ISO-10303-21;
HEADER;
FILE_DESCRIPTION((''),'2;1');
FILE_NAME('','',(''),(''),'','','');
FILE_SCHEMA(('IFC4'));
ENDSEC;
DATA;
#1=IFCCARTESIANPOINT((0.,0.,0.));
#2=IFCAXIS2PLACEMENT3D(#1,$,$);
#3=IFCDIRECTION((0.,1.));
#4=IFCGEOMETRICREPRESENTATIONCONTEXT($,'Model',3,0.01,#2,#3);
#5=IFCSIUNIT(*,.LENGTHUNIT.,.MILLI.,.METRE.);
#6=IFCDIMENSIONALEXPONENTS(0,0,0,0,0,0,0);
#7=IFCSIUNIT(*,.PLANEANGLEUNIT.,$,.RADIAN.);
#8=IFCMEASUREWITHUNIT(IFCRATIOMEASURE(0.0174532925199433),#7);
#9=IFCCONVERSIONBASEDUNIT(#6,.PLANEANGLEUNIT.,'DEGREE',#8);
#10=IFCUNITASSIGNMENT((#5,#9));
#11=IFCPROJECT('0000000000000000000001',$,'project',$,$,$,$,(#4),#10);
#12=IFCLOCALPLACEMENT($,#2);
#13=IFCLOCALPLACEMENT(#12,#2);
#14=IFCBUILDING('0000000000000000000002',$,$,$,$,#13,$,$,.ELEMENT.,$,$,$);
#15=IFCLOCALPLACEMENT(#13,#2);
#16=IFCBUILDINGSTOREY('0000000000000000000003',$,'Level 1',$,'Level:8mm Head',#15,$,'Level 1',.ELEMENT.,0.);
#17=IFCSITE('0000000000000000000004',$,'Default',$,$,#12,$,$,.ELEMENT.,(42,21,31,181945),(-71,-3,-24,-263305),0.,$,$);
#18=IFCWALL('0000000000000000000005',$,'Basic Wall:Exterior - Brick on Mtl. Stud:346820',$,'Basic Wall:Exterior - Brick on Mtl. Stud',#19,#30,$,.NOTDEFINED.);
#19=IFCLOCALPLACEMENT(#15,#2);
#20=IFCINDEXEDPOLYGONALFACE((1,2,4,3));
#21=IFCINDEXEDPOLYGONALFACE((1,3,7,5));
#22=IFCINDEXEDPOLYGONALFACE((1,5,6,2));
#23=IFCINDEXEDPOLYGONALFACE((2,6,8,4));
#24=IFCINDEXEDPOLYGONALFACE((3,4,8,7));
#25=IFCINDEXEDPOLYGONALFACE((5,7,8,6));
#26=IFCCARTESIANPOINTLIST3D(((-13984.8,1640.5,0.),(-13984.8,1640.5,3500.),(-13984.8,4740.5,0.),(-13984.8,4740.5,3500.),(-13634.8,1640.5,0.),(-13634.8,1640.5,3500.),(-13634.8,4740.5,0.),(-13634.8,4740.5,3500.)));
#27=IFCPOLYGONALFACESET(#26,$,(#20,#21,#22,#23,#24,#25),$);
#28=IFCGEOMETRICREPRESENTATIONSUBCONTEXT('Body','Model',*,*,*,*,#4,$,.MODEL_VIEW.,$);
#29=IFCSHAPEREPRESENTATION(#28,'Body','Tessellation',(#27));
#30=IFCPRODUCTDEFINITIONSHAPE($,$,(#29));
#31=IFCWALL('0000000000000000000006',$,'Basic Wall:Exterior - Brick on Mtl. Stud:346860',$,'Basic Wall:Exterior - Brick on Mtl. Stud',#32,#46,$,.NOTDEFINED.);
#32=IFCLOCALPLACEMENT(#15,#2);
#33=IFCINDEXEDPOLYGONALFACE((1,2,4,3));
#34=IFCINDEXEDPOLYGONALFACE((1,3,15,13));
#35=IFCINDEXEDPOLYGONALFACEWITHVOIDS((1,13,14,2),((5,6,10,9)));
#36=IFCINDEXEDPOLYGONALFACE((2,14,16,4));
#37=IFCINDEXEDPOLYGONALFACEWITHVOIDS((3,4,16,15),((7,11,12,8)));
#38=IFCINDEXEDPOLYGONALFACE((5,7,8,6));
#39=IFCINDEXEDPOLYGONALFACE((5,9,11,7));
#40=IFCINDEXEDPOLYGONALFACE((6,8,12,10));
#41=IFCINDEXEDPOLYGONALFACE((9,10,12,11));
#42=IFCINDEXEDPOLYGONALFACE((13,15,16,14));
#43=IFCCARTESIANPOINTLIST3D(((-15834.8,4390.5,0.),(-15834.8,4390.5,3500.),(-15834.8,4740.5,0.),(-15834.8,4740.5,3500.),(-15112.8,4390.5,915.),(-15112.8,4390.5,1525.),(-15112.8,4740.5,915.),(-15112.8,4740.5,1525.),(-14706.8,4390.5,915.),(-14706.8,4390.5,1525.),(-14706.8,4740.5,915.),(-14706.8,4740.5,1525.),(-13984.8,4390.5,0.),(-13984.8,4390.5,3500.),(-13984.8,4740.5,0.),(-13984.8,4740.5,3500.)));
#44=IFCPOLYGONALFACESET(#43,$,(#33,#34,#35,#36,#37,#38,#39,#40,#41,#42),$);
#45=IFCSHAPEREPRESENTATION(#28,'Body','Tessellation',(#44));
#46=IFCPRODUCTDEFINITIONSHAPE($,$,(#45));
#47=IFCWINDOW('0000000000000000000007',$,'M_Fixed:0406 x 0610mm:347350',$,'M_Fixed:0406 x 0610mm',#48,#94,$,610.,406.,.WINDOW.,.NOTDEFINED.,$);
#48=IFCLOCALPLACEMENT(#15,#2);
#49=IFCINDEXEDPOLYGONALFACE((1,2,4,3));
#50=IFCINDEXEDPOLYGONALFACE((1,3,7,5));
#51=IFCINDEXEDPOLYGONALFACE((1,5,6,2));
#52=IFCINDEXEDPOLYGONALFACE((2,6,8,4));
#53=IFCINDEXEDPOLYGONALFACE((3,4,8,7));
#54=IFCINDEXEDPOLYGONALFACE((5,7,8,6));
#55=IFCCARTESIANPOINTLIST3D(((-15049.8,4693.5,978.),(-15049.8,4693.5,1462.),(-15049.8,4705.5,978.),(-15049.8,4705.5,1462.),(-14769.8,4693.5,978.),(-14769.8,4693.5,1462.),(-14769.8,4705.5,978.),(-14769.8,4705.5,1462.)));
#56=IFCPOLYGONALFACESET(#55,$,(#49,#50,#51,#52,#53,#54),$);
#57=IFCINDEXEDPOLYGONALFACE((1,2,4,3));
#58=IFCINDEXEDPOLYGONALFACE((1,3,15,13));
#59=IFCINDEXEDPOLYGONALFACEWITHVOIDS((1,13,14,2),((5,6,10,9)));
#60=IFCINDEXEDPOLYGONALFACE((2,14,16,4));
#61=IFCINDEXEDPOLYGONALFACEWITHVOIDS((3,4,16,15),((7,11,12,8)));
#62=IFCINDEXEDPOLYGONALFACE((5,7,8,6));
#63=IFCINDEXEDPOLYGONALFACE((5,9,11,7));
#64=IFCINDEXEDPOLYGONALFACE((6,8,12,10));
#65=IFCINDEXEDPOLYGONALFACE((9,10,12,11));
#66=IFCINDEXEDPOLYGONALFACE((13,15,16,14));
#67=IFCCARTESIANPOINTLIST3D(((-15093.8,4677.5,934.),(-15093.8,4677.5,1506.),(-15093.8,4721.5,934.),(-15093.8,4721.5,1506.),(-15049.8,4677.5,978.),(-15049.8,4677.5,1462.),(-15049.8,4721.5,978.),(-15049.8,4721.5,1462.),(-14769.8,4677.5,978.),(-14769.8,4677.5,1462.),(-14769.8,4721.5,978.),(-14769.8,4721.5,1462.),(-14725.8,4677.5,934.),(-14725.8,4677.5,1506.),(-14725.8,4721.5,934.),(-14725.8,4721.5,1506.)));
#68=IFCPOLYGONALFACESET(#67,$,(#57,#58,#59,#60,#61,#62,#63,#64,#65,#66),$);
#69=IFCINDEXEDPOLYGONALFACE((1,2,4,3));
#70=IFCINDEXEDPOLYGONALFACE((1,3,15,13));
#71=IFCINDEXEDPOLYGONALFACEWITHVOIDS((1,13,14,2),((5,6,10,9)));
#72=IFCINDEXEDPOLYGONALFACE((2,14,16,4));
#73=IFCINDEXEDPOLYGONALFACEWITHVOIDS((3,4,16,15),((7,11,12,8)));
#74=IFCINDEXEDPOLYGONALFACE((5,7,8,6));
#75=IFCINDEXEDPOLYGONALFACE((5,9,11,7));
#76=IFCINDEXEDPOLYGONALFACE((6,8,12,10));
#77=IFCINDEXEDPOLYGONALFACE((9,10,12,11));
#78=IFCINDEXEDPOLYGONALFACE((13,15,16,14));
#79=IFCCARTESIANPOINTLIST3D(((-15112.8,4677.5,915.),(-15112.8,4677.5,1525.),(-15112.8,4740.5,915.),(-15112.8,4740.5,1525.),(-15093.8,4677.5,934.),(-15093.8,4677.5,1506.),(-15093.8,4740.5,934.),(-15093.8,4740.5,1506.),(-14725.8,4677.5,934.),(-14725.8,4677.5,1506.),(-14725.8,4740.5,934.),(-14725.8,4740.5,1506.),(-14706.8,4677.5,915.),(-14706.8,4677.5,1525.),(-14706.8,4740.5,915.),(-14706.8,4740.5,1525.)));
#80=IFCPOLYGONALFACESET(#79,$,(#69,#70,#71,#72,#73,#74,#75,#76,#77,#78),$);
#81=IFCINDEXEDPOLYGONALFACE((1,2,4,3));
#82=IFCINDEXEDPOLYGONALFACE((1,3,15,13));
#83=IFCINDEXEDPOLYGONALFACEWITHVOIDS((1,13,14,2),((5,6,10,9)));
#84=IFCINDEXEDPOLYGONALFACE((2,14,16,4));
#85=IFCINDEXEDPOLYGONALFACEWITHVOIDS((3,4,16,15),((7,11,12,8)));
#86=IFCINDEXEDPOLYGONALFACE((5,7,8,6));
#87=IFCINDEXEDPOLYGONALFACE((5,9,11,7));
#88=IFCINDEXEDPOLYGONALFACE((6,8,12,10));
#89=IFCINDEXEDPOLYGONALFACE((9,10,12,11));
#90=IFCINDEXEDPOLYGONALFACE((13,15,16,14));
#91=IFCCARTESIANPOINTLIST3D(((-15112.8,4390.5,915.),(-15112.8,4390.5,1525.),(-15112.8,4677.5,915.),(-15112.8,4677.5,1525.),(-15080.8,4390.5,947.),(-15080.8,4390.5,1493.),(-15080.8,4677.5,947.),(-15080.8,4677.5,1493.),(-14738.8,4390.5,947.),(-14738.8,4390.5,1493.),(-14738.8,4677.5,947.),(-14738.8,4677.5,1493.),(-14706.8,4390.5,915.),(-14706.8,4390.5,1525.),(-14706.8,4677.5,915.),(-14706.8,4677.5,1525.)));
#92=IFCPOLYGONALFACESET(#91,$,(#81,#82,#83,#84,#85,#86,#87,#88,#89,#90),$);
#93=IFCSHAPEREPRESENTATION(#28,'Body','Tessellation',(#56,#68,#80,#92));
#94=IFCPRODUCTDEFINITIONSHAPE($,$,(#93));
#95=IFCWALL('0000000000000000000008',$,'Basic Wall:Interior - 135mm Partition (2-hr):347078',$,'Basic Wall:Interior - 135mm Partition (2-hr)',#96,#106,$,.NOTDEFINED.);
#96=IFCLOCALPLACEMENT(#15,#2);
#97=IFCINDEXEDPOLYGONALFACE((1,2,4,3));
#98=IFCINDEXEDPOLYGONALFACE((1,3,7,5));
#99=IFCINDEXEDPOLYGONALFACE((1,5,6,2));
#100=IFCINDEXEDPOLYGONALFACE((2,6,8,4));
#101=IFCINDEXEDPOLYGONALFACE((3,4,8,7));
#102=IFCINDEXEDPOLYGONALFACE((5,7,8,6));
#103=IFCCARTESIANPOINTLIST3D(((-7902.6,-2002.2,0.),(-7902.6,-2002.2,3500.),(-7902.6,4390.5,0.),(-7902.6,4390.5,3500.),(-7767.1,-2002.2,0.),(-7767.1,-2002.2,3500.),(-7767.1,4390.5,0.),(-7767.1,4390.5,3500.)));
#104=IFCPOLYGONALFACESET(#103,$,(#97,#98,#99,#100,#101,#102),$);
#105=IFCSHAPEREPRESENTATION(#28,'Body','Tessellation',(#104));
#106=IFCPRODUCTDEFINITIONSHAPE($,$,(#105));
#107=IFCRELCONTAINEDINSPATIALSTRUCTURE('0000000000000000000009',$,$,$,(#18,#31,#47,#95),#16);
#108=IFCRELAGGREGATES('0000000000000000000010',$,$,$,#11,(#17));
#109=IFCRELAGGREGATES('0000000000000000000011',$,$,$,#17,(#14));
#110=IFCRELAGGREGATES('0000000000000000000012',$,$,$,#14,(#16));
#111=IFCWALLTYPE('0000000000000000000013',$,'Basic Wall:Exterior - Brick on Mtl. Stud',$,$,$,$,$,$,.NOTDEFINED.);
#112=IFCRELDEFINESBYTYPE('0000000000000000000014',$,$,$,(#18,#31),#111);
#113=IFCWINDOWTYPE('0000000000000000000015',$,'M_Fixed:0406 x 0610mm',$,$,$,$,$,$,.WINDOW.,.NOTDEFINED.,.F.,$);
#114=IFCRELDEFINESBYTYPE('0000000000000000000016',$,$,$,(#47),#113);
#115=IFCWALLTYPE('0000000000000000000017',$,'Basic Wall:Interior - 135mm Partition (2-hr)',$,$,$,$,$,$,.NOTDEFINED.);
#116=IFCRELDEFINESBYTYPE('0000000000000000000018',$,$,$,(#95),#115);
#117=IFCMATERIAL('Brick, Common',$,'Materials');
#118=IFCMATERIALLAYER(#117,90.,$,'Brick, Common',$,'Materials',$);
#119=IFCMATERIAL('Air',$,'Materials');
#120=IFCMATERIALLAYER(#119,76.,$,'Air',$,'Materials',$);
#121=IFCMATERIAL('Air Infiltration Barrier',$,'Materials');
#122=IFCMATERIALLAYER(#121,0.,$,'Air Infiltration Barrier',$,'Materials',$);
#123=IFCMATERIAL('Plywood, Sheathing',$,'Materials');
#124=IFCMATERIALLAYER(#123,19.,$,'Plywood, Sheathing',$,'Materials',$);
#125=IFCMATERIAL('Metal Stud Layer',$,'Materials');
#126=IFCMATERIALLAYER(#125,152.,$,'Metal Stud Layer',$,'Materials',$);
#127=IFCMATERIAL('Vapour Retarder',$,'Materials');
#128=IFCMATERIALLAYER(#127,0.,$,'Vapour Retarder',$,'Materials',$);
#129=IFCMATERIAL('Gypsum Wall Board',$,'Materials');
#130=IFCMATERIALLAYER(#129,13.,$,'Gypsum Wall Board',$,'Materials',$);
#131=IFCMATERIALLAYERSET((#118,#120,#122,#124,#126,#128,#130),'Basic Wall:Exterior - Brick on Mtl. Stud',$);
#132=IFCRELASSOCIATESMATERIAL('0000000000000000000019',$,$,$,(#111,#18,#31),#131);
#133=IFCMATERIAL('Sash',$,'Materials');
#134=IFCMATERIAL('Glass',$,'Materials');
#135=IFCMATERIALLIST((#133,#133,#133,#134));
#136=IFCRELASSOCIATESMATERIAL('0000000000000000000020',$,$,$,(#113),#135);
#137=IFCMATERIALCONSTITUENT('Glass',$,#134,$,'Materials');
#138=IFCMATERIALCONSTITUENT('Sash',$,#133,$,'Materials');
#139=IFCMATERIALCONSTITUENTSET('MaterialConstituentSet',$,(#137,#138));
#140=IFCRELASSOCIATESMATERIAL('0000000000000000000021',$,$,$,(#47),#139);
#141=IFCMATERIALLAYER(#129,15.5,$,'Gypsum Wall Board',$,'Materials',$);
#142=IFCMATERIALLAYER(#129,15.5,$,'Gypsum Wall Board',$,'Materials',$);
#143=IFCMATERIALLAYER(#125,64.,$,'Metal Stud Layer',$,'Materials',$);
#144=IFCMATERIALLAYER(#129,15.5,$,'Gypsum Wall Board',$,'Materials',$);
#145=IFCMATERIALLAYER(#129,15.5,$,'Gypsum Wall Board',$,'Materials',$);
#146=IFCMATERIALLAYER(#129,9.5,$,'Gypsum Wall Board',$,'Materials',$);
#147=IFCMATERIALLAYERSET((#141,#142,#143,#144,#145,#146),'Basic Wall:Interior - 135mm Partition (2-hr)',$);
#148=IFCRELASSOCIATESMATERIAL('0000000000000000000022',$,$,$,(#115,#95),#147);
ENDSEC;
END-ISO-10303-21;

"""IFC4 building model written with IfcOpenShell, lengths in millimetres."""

from ifc_helpers import new_model, entity, si_unit, converted_unit, direction, frame, frame_2d, origin, place, context, subcontext, project, spatial, polyline, rectangle, outline, extrude, source, transform, mapped, material, material_list, layer, layer_set, layer_usage, constituent, constituent_set, type_object, type_shapes, element, fill, save


model = new_model("IFC4")

# Units and contexts
model_context = context("Model", 3, precision=0.01, world=origin(), true_north=direction((0.0, 1.0)))
body_context = subcontext(model_context, "Body", "Model", "MODEL_VIEW")
ifc_project = project(units=[si_unit("LENGTHUNIT", "METRE", prefix="MILLI"), converted_unit("PLANEANGLEUNIT", "DEGREE", entity("IfcRatioMeasure", 0.0174532925199433), si_unit("PLANEANGLEUNIT", "RADIAN"), dimensions=[0, 0, 0, 0, 0, 0, 0])], contexts=[model_context])

# Site, building, storey
site_placement = place(None, origin())
site = spatial("IfcSite", under=ifc_project, at=site_placement, Name="Default", CompositionType="ELEMENT", RefLatitude=(42, 21, 31, 181945), RefLongitude=(-71, -3, -24, -263305), RefElevation=0.0)
building_placement = place(site_placement, origin())
building = spatial("IfcBuilding", under=site, at=building_placement, CompositionType="ELEMENT")
storey_placement = place(building_placement, origin())
storey = spatial("IfcBuildingStorey", under=building, at=storey_placement, Name="Level 1", ObjectType="Level:8mm Head", LongName="Level 1", CompositionType="ELEMENT", Elevation=0.0)

# Shared definitions
ifc_material_1 = material(Name="Brick, Common", Category="Materials")
ifc_layer_1 = layer(ifc_material_1, 90.0, Name="Brick, Common", Category="Materials")
ifc_material_2 = material(Name="Air", Category="Materials")
ifc_layer_2 = layer(ifc_material_2, 76.0, Name="Air", Category="Materials")
ifc_material_3 = material(Name="Air Infiltration Barrier", Category="Materials")
ifc_layer_3 = layer(ifc_material_3, 0.0, Name="Air Infiltration Barrier", Category="Materials")
ifc_material_4 = material(Name="Plywood, Sheathing", Category="Materials")
ifc_layer_4 = layer(ifc_material_4, 19.0, Name="Plywood, Sheathing", Category="Materials")
ifc_material_5 = material(Name="Metal Stud Layer", Category="Materials")
ifc_layer_5 = layer(ifc_material_5, 152.0, Name="Metal Stud Layer", Category="Materials")
ifc_material_6 = material(Name="Vapour Retarder", Category="Materials")
ifc_layer_6 = layer(ifc_material_6, 0.0, Name="Vapour Retarder", Category="Materials")
ifc_material_7 = material(Name="Gypsum Wall Board", Category="Materials")
ifc_layer_7 = layer(ifc_material_7, 13.0, Name="Gypsum Wall Board", Category="Materials")
ifc_layer_set_1 = layer_set([ifc_layer_1, ifc_layer_2, ifc_layer_3, ifc_layer_4, ifc_layer_5, ifc_layer_6, ifc_layer_7], Name="Basic Wall:Exterior - Brick on Mtl. Stud")
wall_type_1 = type_object("IfcWallType", Name="Basic Wall:Exterior - Brick on Mtl. Stud", PredefinedType="NOTDEFINED", material=ifc_layer_set_1)
ifc_material_8 = material(Name="Glass", Category="Materials")
ifc_material_9 = material(Name="Sash", Category="Materials")
ifc_material_list_1 = material_list([ifc_material_9, ifc_material_9, ifc_material_9, ifc_material_8])
window_type_1 = type_object("IfcWindowType", Name="M_Fixed:0406 x 0610mm", ParameterTakesPrecedence=False, PartitioningType="NOTDEFINED", PredefinedType="WINDOW", material=ifc_material_list_1)
shared_shape_1 = source(origin(), body_context, "Body", "SweptSolid", [
    extrude(rectangle(XDim=12.0, YDim=280.0, at=frame_2d((0.0, 0.0), x_axis=(1.0, 0.0))), frame((203.0, 309.0, 63.0), z_axis=(0.0, 0.0, 1.0), x_axis=(0.0, -1.0, 0.0)), (0.0, 0.0, 1.0), 484.0),
    extrude(outline(polyline([(-184.0, -286.0), (184.0, -286.0), (184.0, 286.0), (-184.0, 286.0), (-184.0, -286.0)]), holes=[polyline([(-140.0, -242.0), (-140.0, 242.0), (140.0, 242.0), (140.0, -242.0), (-140.0, -242.0)])]), frame((203.0, 287.0, 305.0), z_axis=(0.0, 1.0, 0.0), x_axis=(1.0, 0.0, 0.0)), (0.0, 0.0, 1.0), 44.0),
    extrude(outline(polyline([(-203.0, -305.0), (203.0, -305.0), (203.0, 305.0), (-203.0, 305.0), (-203.0, -305.0)]), holes=[polyline([(-184.0, -286.0), (-184.0, 286.0), (184.0, 286.0), (184.0, -286.0), (-184.0, -286.0)])]), frame((203.0, 287.0, 305.0), z_axis=(0.0, 1.0, 0.0), x_axis=(1.0, 0.0, 0.0)), (0.0, 0.0, 1.0), 63.0),
    extrude(outline(polyline([(-203.0, -305.0), (203.0, -305.0), (203.0, 305.0), (-203.0, 305.0), (-203.0, -305.0)]), holes=[polyline([(-171.0, -273.0), (-171.0, 273.0), (171.0, 273.0), (171.0, -273.0), (-171.0, -273.0)])]), frame((203.0, 0.0, 305.0), z_axis=(0.0, 1.0, 0.0), x_axis=(1.0, 0.0, 0.0)), (0.0, 0.0, 1.0), 287.0),
])
type_shapes(window_type_1, [shared_shape_1])

# Wall
ifc_layer_usage_1 = layer_usage(ifc_layer_set_1, "AXIS2", "NEGATIVE", 175.0)
wall_1_placement = place(storey_placement, frame((-13809.8, 1640.5, 0.0), z_axis=(0.0, 0.0, 1.0), x_axis=(0.0, 1.0, 0.0)))
element("IfcWall", 1, at=wall_1_placement, inside=storey, type_object=wall_type_1, material=ifc_layer_usage_1, Name="Basic Wall:Exterior - Brick on Mtl. Stud:346820", ObjectType="Basic Wall:Exterior - Brick on Mtl. Stud", PredefinedType="NOTDEFINED", context=body_context, shape_type="SweptSolid", body=[
    extrude(rectangle(XDim=3100.0, YDim=350.0, at=frame_2d((1550.0, 0.0), x_axis=(-1.0, 0.0))), origin(), (0.0, 0.0, 1.0), 3500.0),
])

# Wall, opening, window
ifc_layer_usage_2 = layer_usage(ifc_layer_set_1, "AXIS2", "NEGATIVE", 175.0)
wall_2_placement = place(storey_placement, frame((-13984.8, 4565.5, 0.0), z_axis=(0.0, 0.0, 1.0), x_axis=(-1.0, 0.0, 0.0)))
wall_2 = element("IfcWall", 2, at=wall_2_placement, inside=storey, type_object=wall_type_1, material=ifc_layer_usage_2, Name="Basic Wall:Exterior - Brick on Mtl. Stud:346860", ObjectType="Basic Wall:Exterior - Brick on Mtl. Stud", PredefinedType="NOTDEFINED", context=body_context, shape_type="SweptSolid", body=[
    extrude(rectangle(XDim=1850.0, YDim=350.0, at=frame_2d((925.0, 0.0), x_axis=(-1.0, 0.0))), origin(), (0.0, 0.0, 1.0), 3500.0),
])
opening_1_placement = place(wall_2_placement, frame((1128.0, 175.0, 915.0)))
opening_1 = element("IfcOpeningElement", 3, at=opening_1_placement, cuts=wall_2, ObjectType="Opening", PredefinedType="OPENING", context=body_context, shape_type="SweptSolid", body=[
    extrude(rectangle(XDim=610.0, YDim=406.0, at=frame_2d((305.0, 203.0), x_axis=(1.0, 0.0))), frame((0.0, 0.0, 0.0), z_axis=(0.0, -1.0, 0.0), x_axis=(0.0, 0.0, 1.0)), (0.0, 0.0, 1.0), 350.0),
])
ifc_constituent_1 = constituent(ifc_material_8, Name="Glass", Category="Materials")
ifc_constituent_2 = constituent(ifc_material_9, Name="Sash", Category="Materials")
ifc_constituent_set_1 = constituent_set(constituents=[ifc_constituent_1, ifc_constituent_2], Name="MaterialConstituentSet")
window_1_placement = place(opening_1_placement, frame((0.0, 0.0, 0.0), z_axis=(0.0, 0.0, 1.0), x_axis=(-1.0, 0.0, 0.0)))
window_1 = element("IfcWindow", 4, at=window_1_placement, inside=storey, type_object=window_type_1, material=ifc_constituent_set_1, Name="M_Fixed:0406 x 0610mm:347350", ObjectType="M_Fixed:0406 x 0610mm", OverallHeight=610.0, OverallWidth=406.0, PartitioningType="NOTDEFINED", PredefinedType="WINDOW", context=body_context, shape_type="MappedRepresentation", body=[
    mapped(shared_shape_1, transform((0.0, 0.0, 0.0), scale=1.0)),
])
fill(opening_1, window_1)

# Wall
ifc_layer_8 = layer(ifc_material_7, 15.5, Name="Gypsum Wall Board", Category="Materials")
ifc_layer_9 = layer(ifc_material_7, 15.5, Name="Gypsum Wall Board", Category="Materials")
ifc_layer_10 = layer(ifc_material_5, 64.0, Name="Metal Stud Layer", Category="Materials")
ifc_layer_11 = layer(ifc_material_7, 15.5, Name="Gypsum Wall Board", Category="Materials")
ifc_layer_12 = layer(ifc_material_7, 15.5, Name="Gypsum Wall Board", Category="Materials")
ifc_layer_13 = layer(ifc_material_7, 9.5, Name="Gypsum Wall Board", Category="Materials")
ifc_layer_set_2 = layer_set([ifc_layer_8, ifc_layer_9, ifc_layer_10, ifc_layer_11, ifc_layer_12, ifc_layer_13], Name="Basic Wall:Interior - 135mm Partition (2-hr)")
ifc_layer_usage_3 = layer_usage(ifc_layer_set_2, "AXIS2", "NEGATIVE", 67.8)
wall_type_2 = type_object("IfcWallType", Name="Basic Wall:Interior - 135mm Partition (2-hr)", PredefinedType="NOTDEFINED", material=ifc_layer_set_2)
wall_3_placement = place(storey_placement, frame((-7834.8, 4390.5, 0.0), z_axis=(0.0, 0.0, 1.0), x_axis=(0.0, -1.0, 0.0)))
element("IfcWall", 5, at=wall_3_placement, inside=storey, type_object=wall_type_2, material=ifc_layer_usage_3, Name="Basic Wall:Interior - 135mm Partition (2-hr):347078", ObjectType="Basic Wall:Interior - 135mm Partition (2-hr)", PredefinedType="NOTDEFINED", context=body_context, shape_type="SweptSolid", body=[
    extrude(rectangle(XDim=6392.8, YDim=135.5, at=frame_2d((3196.4, 0.0), x_axis=(-1.0, 0.0))), origin(), (0.0, 0.0, 1.0), 3500.0),
])

save(model, "model.ifc")
